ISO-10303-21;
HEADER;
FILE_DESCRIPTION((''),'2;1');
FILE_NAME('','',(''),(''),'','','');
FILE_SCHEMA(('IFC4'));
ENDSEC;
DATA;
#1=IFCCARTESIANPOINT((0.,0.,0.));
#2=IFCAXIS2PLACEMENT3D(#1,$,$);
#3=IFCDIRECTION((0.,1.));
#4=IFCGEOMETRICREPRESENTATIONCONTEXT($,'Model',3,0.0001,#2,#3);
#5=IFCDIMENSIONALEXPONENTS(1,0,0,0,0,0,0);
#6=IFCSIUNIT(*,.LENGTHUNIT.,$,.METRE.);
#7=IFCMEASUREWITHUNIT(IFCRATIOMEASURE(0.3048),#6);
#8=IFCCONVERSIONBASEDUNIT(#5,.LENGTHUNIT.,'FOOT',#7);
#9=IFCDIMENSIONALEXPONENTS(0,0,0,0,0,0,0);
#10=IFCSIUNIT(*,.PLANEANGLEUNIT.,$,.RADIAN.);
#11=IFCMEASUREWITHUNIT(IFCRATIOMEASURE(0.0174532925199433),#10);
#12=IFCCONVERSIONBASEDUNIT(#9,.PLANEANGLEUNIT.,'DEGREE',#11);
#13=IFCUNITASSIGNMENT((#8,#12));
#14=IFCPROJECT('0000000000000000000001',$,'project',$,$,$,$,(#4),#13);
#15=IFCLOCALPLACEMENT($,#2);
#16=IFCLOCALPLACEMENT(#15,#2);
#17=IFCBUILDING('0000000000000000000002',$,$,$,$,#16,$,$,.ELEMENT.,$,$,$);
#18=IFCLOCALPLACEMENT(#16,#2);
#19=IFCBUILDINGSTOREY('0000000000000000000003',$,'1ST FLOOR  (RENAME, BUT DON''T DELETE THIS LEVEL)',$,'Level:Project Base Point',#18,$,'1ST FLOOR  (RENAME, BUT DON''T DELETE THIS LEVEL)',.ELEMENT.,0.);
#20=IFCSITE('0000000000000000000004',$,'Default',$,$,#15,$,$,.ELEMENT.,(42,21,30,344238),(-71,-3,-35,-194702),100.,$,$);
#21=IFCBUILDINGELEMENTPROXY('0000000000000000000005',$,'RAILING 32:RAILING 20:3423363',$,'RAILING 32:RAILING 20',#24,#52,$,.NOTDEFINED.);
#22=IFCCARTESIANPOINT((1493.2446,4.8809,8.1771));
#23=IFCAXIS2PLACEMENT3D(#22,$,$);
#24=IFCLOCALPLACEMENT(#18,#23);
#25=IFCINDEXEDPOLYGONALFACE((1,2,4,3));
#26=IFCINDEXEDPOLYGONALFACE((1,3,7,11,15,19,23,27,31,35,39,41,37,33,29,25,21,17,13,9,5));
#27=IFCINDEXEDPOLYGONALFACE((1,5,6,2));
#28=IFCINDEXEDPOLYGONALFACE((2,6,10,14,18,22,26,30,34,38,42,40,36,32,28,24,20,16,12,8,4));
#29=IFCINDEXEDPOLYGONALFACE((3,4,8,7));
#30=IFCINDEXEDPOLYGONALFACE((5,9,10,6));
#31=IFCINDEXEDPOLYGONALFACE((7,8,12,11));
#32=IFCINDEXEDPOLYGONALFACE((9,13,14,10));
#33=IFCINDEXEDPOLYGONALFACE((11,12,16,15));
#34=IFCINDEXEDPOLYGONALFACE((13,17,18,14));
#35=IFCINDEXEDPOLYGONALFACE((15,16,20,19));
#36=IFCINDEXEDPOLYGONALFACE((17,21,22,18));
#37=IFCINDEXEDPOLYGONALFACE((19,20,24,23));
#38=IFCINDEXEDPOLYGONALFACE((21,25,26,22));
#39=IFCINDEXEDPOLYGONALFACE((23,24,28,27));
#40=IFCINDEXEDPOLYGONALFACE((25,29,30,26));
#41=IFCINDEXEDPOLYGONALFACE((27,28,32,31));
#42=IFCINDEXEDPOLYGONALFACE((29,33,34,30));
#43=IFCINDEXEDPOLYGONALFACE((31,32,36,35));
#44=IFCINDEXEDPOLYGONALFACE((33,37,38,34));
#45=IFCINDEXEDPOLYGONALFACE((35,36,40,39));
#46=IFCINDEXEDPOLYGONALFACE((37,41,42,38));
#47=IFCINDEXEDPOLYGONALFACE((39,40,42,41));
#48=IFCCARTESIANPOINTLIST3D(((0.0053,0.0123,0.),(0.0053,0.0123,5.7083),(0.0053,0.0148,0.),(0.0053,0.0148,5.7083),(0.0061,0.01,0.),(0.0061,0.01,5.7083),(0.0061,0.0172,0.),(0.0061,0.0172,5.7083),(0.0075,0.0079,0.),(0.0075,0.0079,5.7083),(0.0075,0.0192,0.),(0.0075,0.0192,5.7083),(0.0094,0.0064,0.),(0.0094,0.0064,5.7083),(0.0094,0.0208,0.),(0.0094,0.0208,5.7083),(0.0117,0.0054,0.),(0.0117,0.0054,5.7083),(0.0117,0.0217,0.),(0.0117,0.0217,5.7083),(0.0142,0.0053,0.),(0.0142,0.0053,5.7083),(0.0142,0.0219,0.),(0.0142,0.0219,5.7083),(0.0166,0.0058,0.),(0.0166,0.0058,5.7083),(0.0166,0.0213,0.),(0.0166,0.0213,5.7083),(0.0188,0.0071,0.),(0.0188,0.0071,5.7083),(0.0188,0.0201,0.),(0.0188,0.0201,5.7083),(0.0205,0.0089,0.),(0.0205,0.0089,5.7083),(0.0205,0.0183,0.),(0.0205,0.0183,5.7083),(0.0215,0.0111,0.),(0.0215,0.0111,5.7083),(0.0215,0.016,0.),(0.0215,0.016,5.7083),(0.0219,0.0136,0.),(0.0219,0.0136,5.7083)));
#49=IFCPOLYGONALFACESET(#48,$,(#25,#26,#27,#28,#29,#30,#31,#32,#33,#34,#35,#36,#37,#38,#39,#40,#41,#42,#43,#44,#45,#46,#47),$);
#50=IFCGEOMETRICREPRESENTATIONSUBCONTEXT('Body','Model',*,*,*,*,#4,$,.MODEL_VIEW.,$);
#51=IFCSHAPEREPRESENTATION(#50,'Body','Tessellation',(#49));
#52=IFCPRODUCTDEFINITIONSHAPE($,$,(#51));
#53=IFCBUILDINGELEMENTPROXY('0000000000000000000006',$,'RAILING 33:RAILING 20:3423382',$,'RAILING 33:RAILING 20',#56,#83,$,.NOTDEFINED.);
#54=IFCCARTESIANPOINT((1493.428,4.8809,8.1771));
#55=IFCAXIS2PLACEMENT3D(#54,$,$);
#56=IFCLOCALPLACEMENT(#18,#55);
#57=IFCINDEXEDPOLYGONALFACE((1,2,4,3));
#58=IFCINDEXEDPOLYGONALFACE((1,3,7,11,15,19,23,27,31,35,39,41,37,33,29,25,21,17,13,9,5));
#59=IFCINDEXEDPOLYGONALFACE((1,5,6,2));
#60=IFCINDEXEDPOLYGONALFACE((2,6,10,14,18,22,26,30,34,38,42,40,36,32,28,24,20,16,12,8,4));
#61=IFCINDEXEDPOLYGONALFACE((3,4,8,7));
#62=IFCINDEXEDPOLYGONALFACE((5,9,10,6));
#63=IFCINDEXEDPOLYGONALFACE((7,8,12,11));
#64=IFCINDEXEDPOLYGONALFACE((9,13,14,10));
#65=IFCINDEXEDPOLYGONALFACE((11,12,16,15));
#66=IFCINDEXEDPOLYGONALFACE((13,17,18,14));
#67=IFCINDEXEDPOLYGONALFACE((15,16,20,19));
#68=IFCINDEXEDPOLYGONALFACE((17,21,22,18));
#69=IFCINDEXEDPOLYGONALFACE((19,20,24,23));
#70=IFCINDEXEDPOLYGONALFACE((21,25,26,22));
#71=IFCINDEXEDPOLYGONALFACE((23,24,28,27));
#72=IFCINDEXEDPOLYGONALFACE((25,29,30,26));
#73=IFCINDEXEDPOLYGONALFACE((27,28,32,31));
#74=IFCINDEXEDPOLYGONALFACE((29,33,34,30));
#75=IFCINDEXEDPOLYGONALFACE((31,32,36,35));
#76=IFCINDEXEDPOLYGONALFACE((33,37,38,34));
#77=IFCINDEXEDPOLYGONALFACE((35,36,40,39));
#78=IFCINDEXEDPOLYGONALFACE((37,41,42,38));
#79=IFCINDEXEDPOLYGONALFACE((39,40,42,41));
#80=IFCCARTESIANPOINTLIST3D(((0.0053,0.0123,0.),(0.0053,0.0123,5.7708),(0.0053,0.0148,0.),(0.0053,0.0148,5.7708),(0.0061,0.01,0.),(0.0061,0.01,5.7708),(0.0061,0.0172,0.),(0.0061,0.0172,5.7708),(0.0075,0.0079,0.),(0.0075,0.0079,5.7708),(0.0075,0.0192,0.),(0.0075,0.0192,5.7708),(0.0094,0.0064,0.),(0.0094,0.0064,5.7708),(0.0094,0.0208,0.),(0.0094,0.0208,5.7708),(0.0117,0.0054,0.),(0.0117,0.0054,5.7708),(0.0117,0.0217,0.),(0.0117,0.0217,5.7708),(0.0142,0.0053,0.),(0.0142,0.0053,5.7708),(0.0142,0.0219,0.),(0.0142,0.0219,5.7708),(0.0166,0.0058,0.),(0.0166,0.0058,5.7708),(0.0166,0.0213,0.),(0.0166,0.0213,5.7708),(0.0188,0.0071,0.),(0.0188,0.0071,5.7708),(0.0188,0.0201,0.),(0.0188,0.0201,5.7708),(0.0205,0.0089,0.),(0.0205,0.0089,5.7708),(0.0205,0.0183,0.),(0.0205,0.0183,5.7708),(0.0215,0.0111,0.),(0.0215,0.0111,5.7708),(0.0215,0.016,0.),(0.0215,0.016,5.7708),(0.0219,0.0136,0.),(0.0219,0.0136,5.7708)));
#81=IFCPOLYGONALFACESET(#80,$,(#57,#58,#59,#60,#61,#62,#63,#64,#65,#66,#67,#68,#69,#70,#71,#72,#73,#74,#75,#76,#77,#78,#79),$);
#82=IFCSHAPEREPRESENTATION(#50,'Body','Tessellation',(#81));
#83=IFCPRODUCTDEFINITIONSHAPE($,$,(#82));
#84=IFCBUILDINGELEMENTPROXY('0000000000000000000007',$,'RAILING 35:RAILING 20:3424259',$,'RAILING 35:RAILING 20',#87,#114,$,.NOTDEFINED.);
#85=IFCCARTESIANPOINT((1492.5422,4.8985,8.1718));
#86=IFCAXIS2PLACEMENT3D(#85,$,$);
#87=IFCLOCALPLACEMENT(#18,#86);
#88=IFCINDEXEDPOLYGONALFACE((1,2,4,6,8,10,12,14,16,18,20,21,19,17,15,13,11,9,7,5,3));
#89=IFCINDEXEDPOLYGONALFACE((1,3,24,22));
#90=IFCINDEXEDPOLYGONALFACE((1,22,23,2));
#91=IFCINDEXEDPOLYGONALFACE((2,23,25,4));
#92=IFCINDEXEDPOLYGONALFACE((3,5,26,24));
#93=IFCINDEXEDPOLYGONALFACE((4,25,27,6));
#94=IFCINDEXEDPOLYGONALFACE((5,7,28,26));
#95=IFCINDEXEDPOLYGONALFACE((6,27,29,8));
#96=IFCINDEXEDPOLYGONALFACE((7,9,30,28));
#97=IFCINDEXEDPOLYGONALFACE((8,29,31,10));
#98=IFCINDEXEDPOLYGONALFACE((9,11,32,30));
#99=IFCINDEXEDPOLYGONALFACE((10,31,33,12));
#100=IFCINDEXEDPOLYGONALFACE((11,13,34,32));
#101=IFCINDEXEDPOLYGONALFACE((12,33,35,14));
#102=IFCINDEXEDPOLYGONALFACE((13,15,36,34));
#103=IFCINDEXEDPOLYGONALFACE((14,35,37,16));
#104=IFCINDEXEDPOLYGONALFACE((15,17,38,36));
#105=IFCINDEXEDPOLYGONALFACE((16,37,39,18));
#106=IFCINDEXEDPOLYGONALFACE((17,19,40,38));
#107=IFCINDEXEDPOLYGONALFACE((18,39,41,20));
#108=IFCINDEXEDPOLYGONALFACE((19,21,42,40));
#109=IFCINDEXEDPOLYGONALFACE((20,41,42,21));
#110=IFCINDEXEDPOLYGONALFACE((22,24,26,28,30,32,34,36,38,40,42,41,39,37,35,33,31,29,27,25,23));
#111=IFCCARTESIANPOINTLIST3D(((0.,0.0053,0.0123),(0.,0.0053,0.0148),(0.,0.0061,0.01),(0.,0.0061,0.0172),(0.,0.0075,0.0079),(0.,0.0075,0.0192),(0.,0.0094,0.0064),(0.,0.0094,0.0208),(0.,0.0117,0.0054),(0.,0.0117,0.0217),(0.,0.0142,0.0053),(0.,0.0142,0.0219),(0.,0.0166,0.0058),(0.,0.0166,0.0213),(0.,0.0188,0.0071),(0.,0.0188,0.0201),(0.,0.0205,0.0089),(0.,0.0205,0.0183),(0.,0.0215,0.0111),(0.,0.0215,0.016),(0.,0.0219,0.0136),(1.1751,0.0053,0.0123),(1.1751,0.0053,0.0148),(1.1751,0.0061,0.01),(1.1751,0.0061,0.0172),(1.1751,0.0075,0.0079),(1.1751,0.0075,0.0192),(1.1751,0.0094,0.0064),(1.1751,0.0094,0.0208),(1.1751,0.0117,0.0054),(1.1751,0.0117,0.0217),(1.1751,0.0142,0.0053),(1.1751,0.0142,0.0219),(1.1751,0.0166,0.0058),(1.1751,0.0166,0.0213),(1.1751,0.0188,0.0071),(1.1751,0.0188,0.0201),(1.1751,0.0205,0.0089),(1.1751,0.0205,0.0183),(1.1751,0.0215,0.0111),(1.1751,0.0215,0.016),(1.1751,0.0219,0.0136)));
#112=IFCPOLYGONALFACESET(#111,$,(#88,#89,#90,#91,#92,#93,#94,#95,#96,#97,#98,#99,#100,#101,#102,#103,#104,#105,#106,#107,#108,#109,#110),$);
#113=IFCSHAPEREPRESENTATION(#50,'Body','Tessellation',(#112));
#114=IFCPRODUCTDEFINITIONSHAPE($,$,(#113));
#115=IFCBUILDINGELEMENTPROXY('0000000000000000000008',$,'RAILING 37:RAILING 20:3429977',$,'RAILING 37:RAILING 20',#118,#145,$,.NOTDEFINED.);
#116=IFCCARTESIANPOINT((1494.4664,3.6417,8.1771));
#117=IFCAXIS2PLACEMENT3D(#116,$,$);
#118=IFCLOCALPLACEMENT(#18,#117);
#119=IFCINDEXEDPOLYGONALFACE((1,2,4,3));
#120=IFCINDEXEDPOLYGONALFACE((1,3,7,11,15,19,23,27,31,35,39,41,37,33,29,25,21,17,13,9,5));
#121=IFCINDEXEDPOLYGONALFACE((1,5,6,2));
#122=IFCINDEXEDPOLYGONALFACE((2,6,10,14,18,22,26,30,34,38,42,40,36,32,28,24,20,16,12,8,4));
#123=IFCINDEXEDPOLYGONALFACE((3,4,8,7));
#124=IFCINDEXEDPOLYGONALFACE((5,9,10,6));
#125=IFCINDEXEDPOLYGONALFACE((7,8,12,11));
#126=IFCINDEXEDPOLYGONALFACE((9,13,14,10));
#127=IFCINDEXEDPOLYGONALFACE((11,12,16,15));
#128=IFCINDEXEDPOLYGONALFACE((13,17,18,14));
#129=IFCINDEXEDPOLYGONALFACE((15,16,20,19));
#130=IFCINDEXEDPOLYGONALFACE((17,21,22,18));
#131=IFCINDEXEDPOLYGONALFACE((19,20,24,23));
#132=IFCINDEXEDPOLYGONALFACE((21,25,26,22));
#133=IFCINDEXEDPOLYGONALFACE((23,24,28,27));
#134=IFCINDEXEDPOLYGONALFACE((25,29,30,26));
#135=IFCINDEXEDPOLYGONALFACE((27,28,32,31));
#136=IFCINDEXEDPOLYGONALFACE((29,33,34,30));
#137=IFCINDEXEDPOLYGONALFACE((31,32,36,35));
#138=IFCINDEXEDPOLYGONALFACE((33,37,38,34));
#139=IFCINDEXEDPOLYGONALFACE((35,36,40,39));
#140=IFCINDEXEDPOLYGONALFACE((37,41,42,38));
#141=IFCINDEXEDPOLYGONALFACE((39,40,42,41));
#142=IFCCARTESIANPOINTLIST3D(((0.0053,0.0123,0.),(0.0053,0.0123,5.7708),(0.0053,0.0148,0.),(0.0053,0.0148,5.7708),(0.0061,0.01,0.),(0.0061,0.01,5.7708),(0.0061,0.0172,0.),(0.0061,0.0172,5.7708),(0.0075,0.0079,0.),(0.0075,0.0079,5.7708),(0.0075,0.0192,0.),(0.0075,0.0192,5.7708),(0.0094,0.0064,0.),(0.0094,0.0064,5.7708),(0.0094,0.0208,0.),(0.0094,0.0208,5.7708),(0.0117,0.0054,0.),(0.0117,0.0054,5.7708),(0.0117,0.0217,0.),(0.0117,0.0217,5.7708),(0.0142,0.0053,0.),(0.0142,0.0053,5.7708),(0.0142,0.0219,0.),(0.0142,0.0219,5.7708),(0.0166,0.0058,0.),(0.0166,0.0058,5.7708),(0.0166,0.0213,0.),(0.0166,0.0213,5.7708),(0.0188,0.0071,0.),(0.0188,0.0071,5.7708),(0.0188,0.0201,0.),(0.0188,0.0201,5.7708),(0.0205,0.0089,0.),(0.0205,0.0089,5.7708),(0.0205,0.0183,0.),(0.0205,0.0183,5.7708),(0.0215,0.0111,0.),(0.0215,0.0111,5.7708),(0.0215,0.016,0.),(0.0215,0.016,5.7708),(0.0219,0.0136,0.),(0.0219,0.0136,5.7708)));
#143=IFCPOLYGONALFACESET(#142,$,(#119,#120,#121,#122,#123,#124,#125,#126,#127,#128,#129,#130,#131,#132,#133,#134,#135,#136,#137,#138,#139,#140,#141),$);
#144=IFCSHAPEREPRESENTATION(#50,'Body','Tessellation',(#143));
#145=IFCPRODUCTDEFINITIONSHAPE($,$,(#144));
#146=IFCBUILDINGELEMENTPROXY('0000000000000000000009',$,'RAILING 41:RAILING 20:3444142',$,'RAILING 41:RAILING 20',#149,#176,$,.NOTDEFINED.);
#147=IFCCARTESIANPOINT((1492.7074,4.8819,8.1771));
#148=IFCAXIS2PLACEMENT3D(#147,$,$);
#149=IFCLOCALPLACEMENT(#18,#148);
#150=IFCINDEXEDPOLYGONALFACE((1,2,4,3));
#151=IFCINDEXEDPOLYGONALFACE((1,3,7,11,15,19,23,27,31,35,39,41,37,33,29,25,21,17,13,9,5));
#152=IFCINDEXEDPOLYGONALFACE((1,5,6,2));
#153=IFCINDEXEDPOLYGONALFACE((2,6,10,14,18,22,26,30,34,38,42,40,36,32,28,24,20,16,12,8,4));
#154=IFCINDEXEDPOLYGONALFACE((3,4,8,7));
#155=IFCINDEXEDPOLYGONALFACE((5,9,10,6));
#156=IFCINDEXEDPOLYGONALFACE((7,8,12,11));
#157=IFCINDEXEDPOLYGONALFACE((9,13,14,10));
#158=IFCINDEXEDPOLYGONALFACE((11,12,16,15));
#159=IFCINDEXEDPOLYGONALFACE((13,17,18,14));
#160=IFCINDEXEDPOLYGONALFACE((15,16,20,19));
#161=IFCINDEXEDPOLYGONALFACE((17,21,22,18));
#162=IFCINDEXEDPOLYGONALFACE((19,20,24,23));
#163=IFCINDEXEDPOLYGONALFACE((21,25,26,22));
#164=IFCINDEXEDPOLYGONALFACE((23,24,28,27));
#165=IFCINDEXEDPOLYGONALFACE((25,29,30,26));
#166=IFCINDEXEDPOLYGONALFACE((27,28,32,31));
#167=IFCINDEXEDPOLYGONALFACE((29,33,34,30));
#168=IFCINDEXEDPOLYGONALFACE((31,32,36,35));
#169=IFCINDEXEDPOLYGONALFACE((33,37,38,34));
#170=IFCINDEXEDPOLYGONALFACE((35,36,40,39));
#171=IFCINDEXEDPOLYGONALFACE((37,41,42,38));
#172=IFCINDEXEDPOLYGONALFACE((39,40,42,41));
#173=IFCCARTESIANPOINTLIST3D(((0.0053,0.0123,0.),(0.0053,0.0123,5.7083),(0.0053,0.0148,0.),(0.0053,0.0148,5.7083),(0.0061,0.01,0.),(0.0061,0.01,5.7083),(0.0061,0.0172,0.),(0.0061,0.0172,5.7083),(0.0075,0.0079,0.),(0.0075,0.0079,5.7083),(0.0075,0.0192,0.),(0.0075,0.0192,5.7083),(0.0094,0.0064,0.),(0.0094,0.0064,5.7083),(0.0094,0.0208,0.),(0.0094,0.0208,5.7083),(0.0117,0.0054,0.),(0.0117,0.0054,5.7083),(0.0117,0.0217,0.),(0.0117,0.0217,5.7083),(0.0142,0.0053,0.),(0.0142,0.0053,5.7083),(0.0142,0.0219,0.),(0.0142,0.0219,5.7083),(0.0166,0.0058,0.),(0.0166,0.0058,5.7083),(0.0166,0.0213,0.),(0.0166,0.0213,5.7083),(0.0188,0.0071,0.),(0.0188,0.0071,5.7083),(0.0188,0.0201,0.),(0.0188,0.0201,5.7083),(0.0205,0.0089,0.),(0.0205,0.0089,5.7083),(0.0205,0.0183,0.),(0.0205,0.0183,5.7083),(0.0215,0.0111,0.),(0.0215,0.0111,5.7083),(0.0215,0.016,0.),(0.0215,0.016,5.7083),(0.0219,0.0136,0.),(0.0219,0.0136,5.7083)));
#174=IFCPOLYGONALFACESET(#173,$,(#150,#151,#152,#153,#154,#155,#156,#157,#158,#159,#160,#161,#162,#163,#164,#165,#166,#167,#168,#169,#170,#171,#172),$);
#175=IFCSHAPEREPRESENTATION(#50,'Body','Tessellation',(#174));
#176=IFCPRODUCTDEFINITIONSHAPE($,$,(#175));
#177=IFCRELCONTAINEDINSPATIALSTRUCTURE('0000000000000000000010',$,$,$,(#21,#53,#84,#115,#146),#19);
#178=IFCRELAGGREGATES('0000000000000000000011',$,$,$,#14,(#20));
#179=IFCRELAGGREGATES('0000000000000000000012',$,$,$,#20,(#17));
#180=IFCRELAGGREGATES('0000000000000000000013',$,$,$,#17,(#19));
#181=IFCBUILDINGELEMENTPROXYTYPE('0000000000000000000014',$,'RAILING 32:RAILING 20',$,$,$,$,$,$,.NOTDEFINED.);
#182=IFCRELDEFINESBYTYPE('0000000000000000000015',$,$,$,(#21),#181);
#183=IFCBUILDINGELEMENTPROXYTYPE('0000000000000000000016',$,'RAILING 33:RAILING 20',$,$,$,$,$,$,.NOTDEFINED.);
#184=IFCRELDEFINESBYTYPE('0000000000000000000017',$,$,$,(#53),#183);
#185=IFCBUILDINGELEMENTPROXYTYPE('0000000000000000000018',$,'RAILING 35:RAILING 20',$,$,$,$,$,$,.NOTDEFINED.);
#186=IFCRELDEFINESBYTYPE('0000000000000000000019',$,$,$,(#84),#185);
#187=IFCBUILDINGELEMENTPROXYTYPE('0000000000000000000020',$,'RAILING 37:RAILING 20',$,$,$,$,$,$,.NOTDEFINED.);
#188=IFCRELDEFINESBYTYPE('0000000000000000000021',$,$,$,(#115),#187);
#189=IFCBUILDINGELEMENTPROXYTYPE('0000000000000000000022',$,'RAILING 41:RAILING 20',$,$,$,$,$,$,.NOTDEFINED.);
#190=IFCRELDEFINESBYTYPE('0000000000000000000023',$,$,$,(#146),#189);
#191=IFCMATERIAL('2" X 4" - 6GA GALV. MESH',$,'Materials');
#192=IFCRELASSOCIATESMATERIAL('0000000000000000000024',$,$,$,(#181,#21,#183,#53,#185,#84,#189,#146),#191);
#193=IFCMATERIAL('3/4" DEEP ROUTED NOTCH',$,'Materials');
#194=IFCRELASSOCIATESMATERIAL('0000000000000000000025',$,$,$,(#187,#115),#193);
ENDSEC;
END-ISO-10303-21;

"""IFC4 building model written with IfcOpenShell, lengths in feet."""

from ifc_helpers import new_model, entity, si_unit, converted_unit, direction, frame, origin, origin_2d_with_axis, place, context, subcontext, project, spatial, circle, extrude, source, transform, mapped, material, type_object, type_shapes, element, save


model = new_model("IFC4")

# Units and contexts
model_context = context("Model", 3, precision=0.0001, world=origin(), true_north=direction((0.0, 1.0)))
body_context = subcontext(model_context, "Body", "Model", "MODEL_VIEW")
ifc_project = project(units=[converted_unit("LENGTHUNIT", "FOOT", entity("IfcRatioMeasure", 0.3048), si_unit("LENGTHUNIT", "METRE"), dimensions=[1, 0, 0, 0, 0, 0, 0]), converted_unit("PLANEANGLEUNIT", "DEGREE", entity("IfcRatioMeasure", 0.0174532925199433), si_unit("PLANEANGLEUNIT", "RADIAN"), dimensions=[0, 0, 0, 0, 0, 0, 0])], contexts=[model_context])

# Site, building, storey
site_placement = place(None, origin())
site = spatial("IfcSite", under=ifc_project, at=site_placement, Name="Default", CompositionType="ELEMENT", RefLatitude=(42, 21, 30, 344238), RefLongitude=(-71, -3, -35, -194702), RefElevation=100.0)
building_placement = place(site_placement, origin())
building = spatial("IfcBuilding", under=site, at=building_placement, CompositionType="ELEMENT")
storey_placement = place(building_placement, origin())
storey = spatial("IfcBuildingStorey", under=building, at=storey_placement, Name="1ST FLOOR  (RENAME, BUT DON'T DELETE THIS LEVEL)", ObjectType="Level:Project Base Point", LongName="1ST FLOOR  (RENAME, BUT DON'T DELETE THIS LEVEL)", CompositionType="ELEMENT", Elevation=0.0)

# Building element proxies
ifc_material_1 = material(Name="2\" X 4\" - 6GA GALV. MESH", Category="Materials")
building_element_proxy_type_1 = type_object("IfcBuildingElementProxyType", Name="RAILING 32:RAILING 20", PredefinedType="NOTDEFINED", material=ifc_material_1)
shared_shape_1 = source(origin(), body_context, "Body", "SweptSolid", [
    extrude(circle(Radius=0.0083, at=origin_2d_with_axis()), frame((0.0136, 0.0136, 0.0)), (0.0, 0.0, 1.0), 5.7083),
])
type_shapes(building_element_proxy_type_1, [shared_shape_1])
proxy_1_placement = place(storey_placement, frame((1493.2446, 4.8809, 8.1771)))
element("IfcBuildingElementProxy", 1, at=proxy_1_placement, inside=storey, type_object=building_element_proxy_type_1, material=ifc_material_1, Name="RAILING 32:RAILING 20:3423363", ObjectType="RAILING 32:RAILING 20", PredefinedType="NOTDEFINED", context=body_context, shape_type="MappedRepresentation", body=[
    mapped(shared_shape_1, transform((0.0, 0.0, 0.0), scale=1.0)),
])
building_element_proxy_type_2 = type_object("IfcBuildingElementProxyType", Name="RAILING 33:RAILING 20", PredefinedType="NOTDEFINED", material=ifc_material_1)
shared_shape_2 = source(origin(), body_context, "Body", "SweptSolid", [
    extrude(circle(Radius=0.0083, at=origin_2d_with_axis()), frame((0.0136, 0.0136, 0.0)), (0.0, 0.0, 1.0), 5.7708),
])
type_shapes(building_element_proxy_type_2, [shared_shape_2])
proxy_2_placement = place(storey_placement, frame((1493.428, 4.8809, 8.1771)))
element("IfcBuildingElementProxy", 2, at=proxy_2_placement, inside=storey, type_object=building_element_proxy_type_2, material=ifc_material_1, Name="RAILING 33:RAILING 20:3423382", ObjectType="RAILING 33:RAILING 20", PredefinedType="NOTDEFINED", context=body_context, shape_type="MappedRepresentation", body=[
    mapped(shared_shape_2, transform((0.0, 0.0, 0.0), scale=1.0)),
])
building_element_proxy_type_3 = type_object("IfcBuildingElementProxyType", Name="RAILING 35:RAILING 20", PredefinedType="NOTDEFINED", material=ifc_material_1)
shared_shape_3 = source(origin(), body_context, "Body", "SweptSolid", [
    extrude(circle(Radius=0.0083, at=origin_2d_with_axis()), frame((0.0, 0.0136, 0.0136), z_axis=(1.0, 0.0, 0.0), x_axis=(0.0, 1.0, 0.0)), (0.0, 0.0, 1.0), 1.1751),
])
type_shapes(building_element_proxy_type_3, [shared_shape_3])
proxy_3_placement = place(storey_placement, frame((1492.5422, 4.8985, 8.1718)))
element("IfcBuildingElementProxy", 3, at=proxy_3_placement, inside=storey, type_object=building_element_proxy_type_3, material=ifc_material_1, Name="RAILING 35:RAILING 20:3424259", ObjectType="RAILING 35:RAILING 20", PredefinedType="NOTDEFINED", context=body_context, shape_type="MappedRepresentation", body=[
    mapped(shared_shape_3, transform((0.0, 0.0, 0.0), scale=1.0)),
])
ifc_material_2 = material(Name="3/4\" DEEP ROUTED NOTCH", Category="Materials")
building_element_proxy_type_4 = type_object("IfcBuildingElementProxyType", Name="RAILING 37:RAILING 20", PredefinedType="NOTDEFINED", material=ifc_material_2)
shared_shape_4 = source(origin(), body_context, "Body", "SweptSolid", [
    extrude(circle(Radius=0.0083, at=origin_2d_with_axis()), frame((0.0136, 0.0136, 0.0)), (0.0, 0.0, 1.0), 5.7708),
])
type_shapes(building_element_proxy_type_4, [shared_shape_4])
proxy_4_placement = place(storey_placement, frame((1494.4664, 3.6417, 8.1771)))
element("IfcBuildingElementProxy", 4, at=proxy_4_placement, inside=storey, type_object=building_element_proxy_type_4, material=ifc_material_2, Name="RAILING 37:RAILING 20:3429977", ObjectType="RAILING 37:RAILING 20", PredefinedType="NOTDEFINED", context=body_context, shape_type="MappedRepresentation", body=[
    mapped(shared_shape_4, transform((0.0, 0.0, 0.0), scale=1.0)),
])
building_element_proxy_type_5 = type_object("IfcBuildingElementProxyType", Name="RAILING 41:RAILING 20", PredefinedType="NOTDEFINED", material=ifc_material_1)
shared_shape_5 = source(origin(), body_context, "Body", "SweptSolid", [
    extrude(circle(Radius=0.0083, at=origin_2d_with_axis()), frame((0.0136, 0.0136, 0.0)), (0.0, 0.0, 1.0), 5.7083),
])
type_shapes(building_element_proxy_type_5, [shared_shape_5])
proxy_5_placement = place(storey_placement, frame((1492.7074, 4.8819, 8.1771)))
element("IfcBuildingElementProxy", 5, at=proxy_5_placement, inside=storey, type_object=building_element_proxy_type_5, material=ifc_material_1, Name="RAILING 41:RAILING 20:3444142", ObjectType="RAILING 41:RAILING 20", PredefinedType="NOTDEFINED", context=body_context, shape_type="MappedRepresentation", body=[
    mapped(shared_shape_5, transform((0.0, 0.0, 0.0), scale=1.0)),
])

save(model, "model.ifc")
